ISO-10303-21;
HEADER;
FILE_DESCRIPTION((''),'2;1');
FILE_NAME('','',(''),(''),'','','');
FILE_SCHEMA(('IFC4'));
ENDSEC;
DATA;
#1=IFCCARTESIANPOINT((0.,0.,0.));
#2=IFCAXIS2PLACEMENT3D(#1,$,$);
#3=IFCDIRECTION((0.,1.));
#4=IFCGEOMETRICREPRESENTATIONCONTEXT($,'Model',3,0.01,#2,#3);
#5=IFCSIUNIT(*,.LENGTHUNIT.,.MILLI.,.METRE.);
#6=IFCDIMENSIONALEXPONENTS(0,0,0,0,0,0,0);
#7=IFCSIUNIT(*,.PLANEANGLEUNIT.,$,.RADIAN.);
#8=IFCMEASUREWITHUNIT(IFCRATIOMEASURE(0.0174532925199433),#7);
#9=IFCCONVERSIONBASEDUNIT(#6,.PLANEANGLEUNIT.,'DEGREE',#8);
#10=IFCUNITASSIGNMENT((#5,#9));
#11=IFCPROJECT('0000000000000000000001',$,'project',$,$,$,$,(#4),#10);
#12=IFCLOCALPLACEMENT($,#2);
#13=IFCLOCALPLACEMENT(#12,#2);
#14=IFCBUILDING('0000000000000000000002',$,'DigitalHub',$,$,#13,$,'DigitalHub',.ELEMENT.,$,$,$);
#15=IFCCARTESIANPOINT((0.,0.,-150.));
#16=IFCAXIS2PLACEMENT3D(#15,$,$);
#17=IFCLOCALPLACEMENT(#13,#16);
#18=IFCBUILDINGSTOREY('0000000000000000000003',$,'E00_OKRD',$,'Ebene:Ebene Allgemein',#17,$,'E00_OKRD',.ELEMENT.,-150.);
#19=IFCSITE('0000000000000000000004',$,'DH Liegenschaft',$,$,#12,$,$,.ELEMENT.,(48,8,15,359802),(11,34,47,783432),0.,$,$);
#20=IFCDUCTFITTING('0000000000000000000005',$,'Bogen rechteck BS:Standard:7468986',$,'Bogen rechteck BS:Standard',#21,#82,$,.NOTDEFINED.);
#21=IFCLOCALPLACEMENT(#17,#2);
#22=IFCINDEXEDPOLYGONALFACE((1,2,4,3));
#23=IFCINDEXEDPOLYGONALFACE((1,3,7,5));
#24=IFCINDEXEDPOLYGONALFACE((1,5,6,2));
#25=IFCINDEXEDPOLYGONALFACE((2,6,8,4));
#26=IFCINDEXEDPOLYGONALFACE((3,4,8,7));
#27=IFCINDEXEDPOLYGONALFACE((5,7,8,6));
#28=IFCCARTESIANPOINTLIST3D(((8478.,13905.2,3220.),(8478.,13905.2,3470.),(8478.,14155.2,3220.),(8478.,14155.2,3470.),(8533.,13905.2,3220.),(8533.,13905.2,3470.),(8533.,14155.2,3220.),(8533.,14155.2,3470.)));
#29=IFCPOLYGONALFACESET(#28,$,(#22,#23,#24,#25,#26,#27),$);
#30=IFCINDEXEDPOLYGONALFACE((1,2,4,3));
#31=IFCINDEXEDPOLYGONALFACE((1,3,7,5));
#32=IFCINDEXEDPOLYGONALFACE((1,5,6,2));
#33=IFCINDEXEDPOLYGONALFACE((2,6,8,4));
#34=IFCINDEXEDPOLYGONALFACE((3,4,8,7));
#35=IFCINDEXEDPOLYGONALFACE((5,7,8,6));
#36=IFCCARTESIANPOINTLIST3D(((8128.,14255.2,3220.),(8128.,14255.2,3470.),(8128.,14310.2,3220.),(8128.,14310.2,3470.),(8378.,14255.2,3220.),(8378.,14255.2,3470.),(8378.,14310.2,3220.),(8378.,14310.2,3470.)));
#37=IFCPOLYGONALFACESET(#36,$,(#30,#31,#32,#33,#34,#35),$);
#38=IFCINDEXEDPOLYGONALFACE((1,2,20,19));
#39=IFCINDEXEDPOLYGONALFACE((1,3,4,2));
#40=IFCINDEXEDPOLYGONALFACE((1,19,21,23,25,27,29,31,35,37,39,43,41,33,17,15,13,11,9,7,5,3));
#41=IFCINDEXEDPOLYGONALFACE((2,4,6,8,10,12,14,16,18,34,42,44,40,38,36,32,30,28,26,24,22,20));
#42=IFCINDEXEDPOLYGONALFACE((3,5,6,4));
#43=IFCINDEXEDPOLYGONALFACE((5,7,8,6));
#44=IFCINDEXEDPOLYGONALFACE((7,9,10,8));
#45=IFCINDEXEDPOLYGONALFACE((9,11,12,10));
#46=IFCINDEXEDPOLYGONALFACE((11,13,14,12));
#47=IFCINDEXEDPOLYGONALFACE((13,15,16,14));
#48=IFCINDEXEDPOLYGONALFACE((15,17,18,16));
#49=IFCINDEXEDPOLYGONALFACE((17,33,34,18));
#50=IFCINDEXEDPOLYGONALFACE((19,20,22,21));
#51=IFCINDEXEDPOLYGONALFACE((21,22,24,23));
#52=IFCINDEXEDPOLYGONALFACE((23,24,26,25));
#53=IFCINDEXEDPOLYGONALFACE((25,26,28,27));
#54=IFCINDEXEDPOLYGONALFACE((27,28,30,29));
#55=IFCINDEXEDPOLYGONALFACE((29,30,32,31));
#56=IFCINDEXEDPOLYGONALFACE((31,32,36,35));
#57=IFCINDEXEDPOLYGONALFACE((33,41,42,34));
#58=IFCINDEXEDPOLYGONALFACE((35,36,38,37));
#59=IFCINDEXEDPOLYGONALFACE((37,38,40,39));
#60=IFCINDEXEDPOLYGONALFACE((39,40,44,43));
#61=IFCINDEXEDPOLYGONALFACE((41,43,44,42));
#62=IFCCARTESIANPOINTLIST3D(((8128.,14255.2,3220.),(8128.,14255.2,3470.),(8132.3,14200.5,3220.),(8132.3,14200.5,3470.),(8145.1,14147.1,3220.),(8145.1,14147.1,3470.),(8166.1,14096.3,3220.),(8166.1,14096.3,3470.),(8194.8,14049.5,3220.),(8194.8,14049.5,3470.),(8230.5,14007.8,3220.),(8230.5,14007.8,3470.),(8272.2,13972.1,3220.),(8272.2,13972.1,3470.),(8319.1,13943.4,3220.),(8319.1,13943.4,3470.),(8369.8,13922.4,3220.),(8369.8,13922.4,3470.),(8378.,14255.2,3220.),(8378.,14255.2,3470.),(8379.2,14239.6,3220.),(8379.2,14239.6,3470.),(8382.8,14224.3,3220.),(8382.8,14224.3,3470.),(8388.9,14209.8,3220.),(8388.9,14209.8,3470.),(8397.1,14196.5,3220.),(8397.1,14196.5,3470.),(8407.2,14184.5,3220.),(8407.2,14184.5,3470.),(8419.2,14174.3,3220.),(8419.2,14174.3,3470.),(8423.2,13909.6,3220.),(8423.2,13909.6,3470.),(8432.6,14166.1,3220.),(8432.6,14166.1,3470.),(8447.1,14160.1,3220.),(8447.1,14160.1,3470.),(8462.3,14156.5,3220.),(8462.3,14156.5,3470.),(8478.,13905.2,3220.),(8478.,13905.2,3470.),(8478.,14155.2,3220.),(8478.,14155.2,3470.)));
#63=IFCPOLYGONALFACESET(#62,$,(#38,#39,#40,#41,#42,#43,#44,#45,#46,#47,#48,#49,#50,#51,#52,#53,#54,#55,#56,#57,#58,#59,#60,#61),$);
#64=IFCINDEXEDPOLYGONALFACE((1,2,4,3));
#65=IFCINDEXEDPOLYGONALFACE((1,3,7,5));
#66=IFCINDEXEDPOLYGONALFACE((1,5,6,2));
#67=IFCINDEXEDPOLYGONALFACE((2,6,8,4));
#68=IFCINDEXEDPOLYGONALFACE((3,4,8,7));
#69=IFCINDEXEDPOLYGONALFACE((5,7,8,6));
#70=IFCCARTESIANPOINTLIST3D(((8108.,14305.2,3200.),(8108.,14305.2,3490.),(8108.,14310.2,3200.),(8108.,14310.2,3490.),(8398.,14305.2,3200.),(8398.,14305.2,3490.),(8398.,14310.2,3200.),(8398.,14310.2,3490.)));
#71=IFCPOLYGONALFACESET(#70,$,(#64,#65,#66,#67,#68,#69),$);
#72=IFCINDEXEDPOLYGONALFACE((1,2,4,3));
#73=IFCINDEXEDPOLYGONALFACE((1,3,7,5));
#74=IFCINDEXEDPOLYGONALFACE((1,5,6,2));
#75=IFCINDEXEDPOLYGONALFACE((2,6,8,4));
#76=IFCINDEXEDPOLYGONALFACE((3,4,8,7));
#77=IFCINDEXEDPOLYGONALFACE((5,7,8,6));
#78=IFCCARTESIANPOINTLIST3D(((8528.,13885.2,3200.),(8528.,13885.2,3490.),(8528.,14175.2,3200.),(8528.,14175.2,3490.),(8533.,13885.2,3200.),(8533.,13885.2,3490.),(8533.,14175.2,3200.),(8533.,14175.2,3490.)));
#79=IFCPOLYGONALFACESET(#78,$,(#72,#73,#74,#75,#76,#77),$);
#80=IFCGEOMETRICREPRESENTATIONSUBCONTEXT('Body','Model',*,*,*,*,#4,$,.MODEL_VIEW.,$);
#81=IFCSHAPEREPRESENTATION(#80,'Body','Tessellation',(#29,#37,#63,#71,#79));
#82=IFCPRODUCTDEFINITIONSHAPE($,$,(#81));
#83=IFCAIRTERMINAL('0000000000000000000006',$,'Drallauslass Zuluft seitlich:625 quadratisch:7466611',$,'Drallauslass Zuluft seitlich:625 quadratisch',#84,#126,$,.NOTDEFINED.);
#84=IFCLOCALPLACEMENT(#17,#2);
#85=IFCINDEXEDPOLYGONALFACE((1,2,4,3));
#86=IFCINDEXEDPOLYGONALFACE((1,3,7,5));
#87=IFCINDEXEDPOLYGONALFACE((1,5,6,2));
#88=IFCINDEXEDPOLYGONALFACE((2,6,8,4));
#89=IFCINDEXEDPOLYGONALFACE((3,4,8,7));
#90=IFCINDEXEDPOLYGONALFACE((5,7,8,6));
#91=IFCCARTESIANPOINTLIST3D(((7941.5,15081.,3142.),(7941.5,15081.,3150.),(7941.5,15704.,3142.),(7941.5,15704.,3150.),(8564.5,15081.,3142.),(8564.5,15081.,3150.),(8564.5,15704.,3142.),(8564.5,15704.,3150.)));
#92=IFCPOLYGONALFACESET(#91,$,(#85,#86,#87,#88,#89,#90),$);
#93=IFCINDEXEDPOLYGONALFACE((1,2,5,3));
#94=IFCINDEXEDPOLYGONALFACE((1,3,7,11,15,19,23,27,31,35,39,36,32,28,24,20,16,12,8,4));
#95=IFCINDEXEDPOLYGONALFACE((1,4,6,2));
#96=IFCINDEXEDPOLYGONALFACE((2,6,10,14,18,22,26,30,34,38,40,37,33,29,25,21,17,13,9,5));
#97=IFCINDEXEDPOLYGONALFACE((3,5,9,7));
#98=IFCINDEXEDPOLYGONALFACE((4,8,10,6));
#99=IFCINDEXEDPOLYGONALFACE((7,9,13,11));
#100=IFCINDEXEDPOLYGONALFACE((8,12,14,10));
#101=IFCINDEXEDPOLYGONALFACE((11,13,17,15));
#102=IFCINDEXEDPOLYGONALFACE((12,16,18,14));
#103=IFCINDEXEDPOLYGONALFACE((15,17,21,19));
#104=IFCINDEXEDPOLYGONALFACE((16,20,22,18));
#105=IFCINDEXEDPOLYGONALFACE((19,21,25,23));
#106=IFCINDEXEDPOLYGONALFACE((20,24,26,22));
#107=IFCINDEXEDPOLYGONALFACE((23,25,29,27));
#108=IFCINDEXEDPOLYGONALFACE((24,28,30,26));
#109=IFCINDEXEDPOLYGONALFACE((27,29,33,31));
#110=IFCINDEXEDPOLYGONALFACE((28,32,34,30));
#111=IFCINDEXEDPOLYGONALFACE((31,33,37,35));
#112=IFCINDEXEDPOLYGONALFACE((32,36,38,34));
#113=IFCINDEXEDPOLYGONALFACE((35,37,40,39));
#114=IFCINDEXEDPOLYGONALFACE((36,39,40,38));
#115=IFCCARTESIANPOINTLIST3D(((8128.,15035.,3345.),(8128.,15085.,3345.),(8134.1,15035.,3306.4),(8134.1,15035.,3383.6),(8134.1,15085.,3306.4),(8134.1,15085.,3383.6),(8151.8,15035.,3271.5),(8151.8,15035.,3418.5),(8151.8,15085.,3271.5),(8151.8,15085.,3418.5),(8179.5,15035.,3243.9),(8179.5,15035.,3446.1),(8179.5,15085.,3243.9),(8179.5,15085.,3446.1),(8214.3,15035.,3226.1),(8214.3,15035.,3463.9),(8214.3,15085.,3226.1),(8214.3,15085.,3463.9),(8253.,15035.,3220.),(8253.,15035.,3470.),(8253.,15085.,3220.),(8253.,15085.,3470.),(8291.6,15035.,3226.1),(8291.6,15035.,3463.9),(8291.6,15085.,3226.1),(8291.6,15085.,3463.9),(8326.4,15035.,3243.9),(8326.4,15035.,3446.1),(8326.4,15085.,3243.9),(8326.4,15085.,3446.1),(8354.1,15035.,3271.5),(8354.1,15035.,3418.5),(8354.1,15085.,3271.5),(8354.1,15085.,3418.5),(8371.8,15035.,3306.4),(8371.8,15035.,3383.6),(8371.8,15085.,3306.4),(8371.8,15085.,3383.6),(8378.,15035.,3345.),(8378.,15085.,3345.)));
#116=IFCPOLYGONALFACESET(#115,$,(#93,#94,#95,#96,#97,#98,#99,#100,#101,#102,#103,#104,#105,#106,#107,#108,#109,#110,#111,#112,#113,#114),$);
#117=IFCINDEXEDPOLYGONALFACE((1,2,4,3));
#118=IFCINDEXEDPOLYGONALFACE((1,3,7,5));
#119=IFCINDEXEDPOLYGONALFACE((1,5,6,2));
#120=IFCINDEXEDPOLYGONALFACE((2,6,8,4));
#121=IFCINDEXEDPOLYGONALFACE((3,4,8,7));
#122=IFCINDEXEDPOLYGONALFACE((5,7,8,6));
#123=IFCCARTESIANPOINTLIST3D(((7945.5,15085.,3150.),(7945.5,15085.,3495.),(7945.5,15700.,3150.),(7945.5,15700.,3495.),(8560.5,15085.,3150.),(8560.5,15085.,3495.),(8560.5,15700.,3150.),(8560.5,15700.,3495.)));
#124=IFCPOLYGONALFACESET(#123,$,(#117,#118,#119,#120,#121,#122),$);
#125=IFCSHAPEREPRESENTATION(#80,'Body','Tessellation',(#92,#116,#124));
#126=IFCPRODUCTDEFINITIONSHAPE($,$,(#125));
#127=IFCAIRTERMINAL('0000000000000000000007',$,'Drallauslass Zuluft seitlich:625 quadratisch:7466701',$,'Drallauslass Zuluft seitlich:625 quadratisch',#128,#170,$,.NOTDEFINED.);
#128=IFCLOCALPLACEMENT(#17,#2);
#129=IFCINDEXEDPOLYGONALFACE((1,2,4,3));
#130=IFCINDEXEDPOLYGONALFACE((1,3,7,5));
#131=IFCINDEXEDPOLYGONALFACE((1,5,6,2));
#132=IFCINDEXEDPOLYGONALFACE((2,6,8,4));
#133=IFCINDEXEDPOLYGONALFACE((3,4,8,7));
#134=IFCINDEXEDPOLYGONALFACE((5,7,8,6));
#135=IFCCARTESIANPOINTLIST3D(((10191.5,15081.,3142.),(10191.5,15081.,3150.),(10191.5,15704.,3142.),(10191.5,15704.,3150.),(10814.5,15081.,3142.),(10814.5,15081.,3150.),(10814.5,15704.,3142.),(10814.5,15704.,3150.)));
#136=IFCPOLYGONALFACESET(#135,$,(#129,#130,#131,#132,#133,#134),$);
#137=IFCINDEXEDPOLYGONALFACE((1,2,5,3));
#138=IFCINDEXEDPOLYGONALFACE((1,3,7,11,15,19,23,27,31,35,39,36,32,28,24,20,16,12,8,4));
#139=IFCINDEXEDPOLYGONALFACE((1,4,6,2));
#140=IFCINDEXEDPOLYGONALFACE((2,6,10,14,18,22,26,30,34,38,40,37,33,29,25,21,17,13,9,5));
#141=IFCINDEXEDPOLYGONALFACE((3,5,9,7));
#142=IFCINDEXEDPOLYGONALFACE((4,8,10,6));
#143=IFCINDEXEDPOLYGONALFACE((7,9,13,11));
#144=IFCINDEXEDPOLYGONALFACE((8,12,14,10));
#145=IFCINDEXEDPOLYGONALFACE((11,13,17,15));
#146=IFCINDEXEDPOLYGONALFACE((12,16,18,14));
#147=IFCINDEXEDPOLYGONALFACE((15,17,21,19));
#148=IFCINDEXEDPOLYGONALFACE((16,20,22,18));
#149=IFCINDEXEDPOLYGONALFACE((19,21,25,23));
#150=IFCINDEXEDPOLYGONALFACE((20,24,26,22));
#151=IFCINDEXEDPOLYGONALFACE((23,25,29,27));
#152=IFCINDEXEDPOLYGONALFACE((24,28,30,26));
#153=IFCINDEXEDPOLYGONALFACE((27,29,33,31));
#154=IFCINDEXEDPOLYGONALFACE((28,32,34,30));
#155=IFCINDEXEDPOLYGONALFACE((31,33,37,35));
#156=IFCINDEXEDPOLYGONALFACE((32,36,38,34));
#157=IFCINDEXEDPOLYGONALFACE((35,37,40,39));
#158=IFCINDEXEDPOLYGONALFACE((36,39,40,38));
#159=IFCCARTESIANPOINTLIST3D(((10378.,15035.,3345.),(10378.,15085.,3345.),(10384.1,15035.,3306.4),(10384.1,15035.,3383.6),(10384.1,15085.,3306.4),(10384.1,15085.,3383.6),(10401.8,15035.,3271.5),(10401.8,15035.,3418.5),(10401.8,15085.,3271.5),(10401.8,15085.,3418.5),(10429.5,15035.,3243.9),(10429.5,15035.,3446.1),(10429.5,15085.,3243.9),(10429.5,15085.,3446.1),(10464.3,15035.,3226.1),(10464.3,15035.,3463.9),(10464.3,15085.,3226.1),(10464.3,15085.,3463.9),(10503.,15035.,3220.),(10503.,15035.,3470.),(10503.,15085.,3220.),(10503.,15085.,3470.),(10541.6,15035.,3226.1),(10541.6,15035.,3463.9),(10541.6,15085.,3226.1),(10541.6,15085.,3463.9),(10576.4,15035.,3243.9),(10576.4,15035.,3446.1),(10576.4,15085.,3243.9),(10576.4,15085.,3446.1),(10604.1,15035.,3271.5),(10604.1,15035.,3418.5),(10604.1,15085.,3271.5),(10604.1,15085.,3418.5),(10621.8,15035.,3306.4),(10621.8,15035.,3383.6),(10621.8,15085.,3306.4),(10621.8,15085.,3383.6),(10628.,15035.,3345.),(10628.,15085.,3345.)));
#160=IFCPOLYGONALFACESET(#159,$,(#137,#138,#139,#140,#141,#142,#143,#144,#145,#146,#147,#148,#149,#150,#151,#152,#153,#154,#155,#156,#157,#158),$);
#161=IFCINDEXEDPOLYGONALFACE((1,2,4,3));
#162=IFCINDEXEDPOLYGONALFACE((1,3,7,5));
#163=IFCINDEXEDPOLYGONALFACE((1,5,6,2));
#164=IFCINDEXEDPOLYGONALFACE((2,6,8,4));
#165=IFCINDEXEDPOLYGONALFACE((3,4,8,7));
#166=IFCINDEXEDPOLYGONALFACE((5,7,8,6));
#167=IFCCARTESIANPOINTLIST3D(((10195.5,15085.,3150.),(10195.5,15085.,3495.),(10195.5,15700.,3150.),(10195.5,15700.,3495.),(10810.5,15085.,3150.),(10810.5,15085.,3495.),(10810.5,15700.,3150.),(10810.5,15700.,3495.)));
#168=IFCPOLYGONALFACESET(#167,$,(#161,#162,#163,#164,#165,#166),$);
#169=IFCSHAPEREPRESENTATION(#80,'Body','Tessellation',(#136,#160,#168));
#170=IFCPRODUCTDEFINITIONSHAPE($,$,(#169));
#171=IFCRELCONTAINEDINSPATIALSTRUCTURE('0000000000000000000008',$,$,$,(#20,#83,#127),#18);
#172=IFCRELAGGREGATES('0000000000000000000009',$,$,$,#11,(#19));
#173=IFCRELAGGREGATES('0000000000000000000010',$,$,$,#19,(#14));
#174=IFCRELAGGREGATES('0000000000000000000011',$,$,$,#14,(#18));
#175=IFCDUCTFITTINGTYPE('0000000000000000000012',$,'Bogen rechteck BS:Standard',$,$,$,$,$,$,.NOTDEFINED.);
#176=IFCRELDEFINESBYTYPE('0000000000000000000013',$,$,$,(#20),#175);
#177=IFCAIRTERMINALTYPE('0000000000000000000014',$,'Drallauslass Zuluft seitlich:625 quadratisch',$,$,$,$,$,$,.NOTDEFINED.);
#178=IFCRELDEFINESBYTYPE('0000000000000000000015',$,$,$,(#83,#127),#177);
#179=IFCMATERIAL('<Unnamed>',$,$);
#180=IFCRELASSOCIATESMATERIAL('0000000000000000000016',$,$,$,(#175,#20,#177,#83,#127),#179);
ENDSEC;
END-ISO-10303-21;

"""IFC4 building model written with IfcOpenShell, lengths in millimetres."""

from ifc_helpers import new_model, entity, si_unit, converted_unit, direction, frame, origin, place, context, subcontext, project, spatial, indexed_curve, outline, extrude, source, transform, mapped, material, type_object, type_shapes, element, save


model = new_model("IFC4")

# Units and contexts
model_context = context("Model", 3, precision=0.01, world=origin(), true_north=direction((0.0, 1.0)))
body_context = subcontext(model_context, "Body", "Model", "MODEL_VIEW")
ifc_project = project(units=[si_unit("LENGTHUNIT", "METRE", prefix="MILLI"), converted_unit("PLANEANGLEUNIT", "DEGREE", entity("IfcRatioMeasure", 0.0174532925199433), si_unit("PLANEANGLEUNIT", "RADIAN"), dimensions=[0, 0, 0, 0, 0, 0, 0])], contexts=[model_context])

# Site, building, storey
site_placement = place(None, origin())
site = spatial("IfcSite", under=ifc_project, at=site_placement, Name="DH Liegenschaft", CompositionType="ELEMENT", RefLatitude=(48, 8, 15, 359802), RefLongitude=(11, 34, 47, 783432), RefElevation=0.0)
building_placement = place(site_placement, origin())
building = spatial("IfcBuilding", under=site, at=building_placement, Name="DigitalHub", LongName="DigitalHub", CompositionType="ELEMENT")
storey_placement = place(building_placement, frame((0.0, 0.0, -150.0)))
storey = spatial("IfcBuildingStorey", under=building, at=storey_placement, Name="E00_OKRD", ObjectType="Ebene:Ebene Allgemein", LongName="E00_OKRD", CompositionType="ELEMENT", Elevation=-150.0)

# Duct fitting
ifc_material_1 = material(Name="<Unnamed>")
duct_fitting_type_1 = type_object("IfcDuctFittingType", Name="Bogen rechteck BS:Standard", PredefinedType="NOTDEFINED", material=ifc_material_1)
shared_shape_1 = source(origin(), body_context, "Body", "SweptSolid", [
    extrude(outline(indexed_curve([(-27.5, -125.0), (27.5, -125.0), (27.5, 125.0), (-27.5, 125.0), (-27.5, -125.0)], self_intersect=False)), frame((0.0, 252.5, -125.0), z_axis=(0.0, 0.0, 1.0), x_axis=(0.0, 1.0, 0.0)), (0.0, 0.0, 1.0), 250.0),
    extrude(outline(indexed_curve([(-125.0, -27.5), (125.0, -27.5), (125.0, 27.5), (-125.0, 27.5), (-125.0, -27.5)], self_intersect=False)), frame((-252.5, 0.0, -125.0), z_axis=(0.0, 0.0, 1.0), x_axis=(0.0, -1.0, 0.0)), (0.0, 0.0, 1.0), 250.0),
    extrude(outline(indexed_curve([(-237.5, -112.5), (12.5, -112.5), (13.7, -96.9), (17.4, -81.6), (23.4, -67.1), (31.6, -53.7), (41.8, -41.8), (53.7, -31.6), (67.1, -23.4), (81.6, -17.4), (96.9, -13.7), (112.5, -12.5), (112.5, 237.5), (57.7, 233.2), (4.3, 220.4), (-46.4, 199.4), (-93.2, 170.7), (-135.0, 135.0), (-170.7, 93.2), (-199.4, 46.4), (-220.4, -4.3), (-233.2, -57.7), (-237.5, -112.5)], self_intersect=False)), frame((-112.5, 112.5, -125.0), z_axis=(0.0, 0.0, 1.0), x_axis=(-1.0, 0.0, 0.0)), (0.0, 0.0, 1.0), 250.0),
    extrude(outline(indexed_curve([(-2.5, -145.0), (2.5, -145.0), (2.5, 145.0), (-2.5, 145.0), (-2.5, -145.0)], self_intersect=False)), frame((-277.5, 0.0, -145.0)), (0.0, 0.0, 1.0), 290.0),
    extrude(outline(indexed_curve([(-2.5, -145.0), (2.5, -145.0), (2.5, 145.0), (-2.5, 145.0), (-2.5, -145.0)], self_intersect=False)), frame((0.0, 277.5, -145.0), z_axis=(0.0, 0.0, 1.0), x_axis=(0.0, 1.0, 0.0)), (0.0, 0.0, 1.0), 290.0),
])
type_shapes(duct_fitting_type_1, [shared_shape_1])
duct_fitting_1_placement = place(storey_placement, frame((8253.0, 14030.2, 3345.0), z_axis=(0.0, 0.0, 1.0), x_axis=(0.0, -1.0, 0.0)))
element("IfcDuctFitting", 1, at=duct_fitting_1_placement, inside=storey, type_object=duct_fitting_type_1, material=ifc_material_1, Name="Bogen rechteck BS:Standard:7468986", ObjectType="Bogen rechteck BS:Standard", PredefinedType="NOTDEFINED", context=body_context, shape_type="MappedRepresentation", body=[
    mapped(shared_shape_1, transform((0.0, 0.0, 0.0), scale=1.0)),
])

# Air terminals
air_terminal_type = type_object("IfcAirTerminalType", Name="Drallauslass Zuluft seitlich:625 quadratisch", PredefinedType="NOTDEFINED", material=ifc_material_1)
shared_shape_2 = source(origin(), body_context, "Body", "SweptSolid", [
    extrude(outline(indexed_curve([(-311.5, -311.5), (311.5, -311.5), (311.5, 311.5), (-311.5, 311.5), (-311.5, -311.5)], self_intersect=False)), frame((0.0, 0.0, -8.0), z_axis=(0.0, 0.0, 1.0), x_axis=(-1.0, 0.0, 0.0)), (0.0, 0.0, 1.0), 8.0),
    extrude(outline(indexed_curve([(125.0, 0.0), (118.9, 38.6), (101.1, 73.5), (73.5, 101.1), (38.6, 118.9), (0.0, 125.0), (-38.6, 118.9), (-73.5, 101.1), (-101.1, 73.5), (-118.9, 38.6), (-125.0, 0.0), (-118.9, -38.6), (-101.1, -73.5), (-73.5, -101.1), (-38.6, -118.9), (0.0, -125.0), (38.6, -118.9), (73.5, -101.1), (101.1, -73.5), (118.9, -38.6), (125.0, 0.0)], self_intersect=False)), frame((-357.5, 0.0, 195.0), z_axis=(1.0, 0.0, 0.0), x_axis=(0.0, 1.0, 0.0)), (0.0, 0.0, 1.0), 50.0),
    extrude(outline(indexed_curve([(-307.5, -307.5), (307.5, -307.5), (307.5, 307.5), (-307.5, 307.5), (-307.5, -307.5)], self_intersect=False)), frame((0.0, 0.0, 0.0), z_axis=(0.0, 0.0, 1.0), x_axis=(-1.0, 0.0, 0.0)), (0.0, 0.0, 1.0), 345.0),
])
type_shapes(air_terminal_type, [shared_shape_2])
for number, where, z_axis, x_axis, name in (
    (2, (8253.0, 15392.5, 3150.0), (0.0, 0.0, 1.0), (0.0, 1.0, 0.0), "Drallauslass Zuluft seitlich:625 quadratisch:7466611"),
    (3, (10503.0, 15392.5, 3150.0), (0.0, 0.0, 1.0), (0.0, 1.0, 0.0), "Drallauslass Zuluft seitlich:625 quadratisch:7466701"),
):
    element("IfcAirTerminal", number, at=place(storey_placement, frame(where, z_axis=z_axis, x_axis=x_axis)), inside=storey, type_object=air_terminal_type, material=ifc_material_1, Name=name, ObjectType="Drallauslass Zuluft seitlich:625 quadratisch", PredefinedType="NOTDEFINED", context=body_context, shape_type="MappedRepresentation", body=[
        mapped(shared_shape_2, transform((0.0, 0.0, 0.0), scale=1.0)),
    ])

save(model, "model.ifc")
